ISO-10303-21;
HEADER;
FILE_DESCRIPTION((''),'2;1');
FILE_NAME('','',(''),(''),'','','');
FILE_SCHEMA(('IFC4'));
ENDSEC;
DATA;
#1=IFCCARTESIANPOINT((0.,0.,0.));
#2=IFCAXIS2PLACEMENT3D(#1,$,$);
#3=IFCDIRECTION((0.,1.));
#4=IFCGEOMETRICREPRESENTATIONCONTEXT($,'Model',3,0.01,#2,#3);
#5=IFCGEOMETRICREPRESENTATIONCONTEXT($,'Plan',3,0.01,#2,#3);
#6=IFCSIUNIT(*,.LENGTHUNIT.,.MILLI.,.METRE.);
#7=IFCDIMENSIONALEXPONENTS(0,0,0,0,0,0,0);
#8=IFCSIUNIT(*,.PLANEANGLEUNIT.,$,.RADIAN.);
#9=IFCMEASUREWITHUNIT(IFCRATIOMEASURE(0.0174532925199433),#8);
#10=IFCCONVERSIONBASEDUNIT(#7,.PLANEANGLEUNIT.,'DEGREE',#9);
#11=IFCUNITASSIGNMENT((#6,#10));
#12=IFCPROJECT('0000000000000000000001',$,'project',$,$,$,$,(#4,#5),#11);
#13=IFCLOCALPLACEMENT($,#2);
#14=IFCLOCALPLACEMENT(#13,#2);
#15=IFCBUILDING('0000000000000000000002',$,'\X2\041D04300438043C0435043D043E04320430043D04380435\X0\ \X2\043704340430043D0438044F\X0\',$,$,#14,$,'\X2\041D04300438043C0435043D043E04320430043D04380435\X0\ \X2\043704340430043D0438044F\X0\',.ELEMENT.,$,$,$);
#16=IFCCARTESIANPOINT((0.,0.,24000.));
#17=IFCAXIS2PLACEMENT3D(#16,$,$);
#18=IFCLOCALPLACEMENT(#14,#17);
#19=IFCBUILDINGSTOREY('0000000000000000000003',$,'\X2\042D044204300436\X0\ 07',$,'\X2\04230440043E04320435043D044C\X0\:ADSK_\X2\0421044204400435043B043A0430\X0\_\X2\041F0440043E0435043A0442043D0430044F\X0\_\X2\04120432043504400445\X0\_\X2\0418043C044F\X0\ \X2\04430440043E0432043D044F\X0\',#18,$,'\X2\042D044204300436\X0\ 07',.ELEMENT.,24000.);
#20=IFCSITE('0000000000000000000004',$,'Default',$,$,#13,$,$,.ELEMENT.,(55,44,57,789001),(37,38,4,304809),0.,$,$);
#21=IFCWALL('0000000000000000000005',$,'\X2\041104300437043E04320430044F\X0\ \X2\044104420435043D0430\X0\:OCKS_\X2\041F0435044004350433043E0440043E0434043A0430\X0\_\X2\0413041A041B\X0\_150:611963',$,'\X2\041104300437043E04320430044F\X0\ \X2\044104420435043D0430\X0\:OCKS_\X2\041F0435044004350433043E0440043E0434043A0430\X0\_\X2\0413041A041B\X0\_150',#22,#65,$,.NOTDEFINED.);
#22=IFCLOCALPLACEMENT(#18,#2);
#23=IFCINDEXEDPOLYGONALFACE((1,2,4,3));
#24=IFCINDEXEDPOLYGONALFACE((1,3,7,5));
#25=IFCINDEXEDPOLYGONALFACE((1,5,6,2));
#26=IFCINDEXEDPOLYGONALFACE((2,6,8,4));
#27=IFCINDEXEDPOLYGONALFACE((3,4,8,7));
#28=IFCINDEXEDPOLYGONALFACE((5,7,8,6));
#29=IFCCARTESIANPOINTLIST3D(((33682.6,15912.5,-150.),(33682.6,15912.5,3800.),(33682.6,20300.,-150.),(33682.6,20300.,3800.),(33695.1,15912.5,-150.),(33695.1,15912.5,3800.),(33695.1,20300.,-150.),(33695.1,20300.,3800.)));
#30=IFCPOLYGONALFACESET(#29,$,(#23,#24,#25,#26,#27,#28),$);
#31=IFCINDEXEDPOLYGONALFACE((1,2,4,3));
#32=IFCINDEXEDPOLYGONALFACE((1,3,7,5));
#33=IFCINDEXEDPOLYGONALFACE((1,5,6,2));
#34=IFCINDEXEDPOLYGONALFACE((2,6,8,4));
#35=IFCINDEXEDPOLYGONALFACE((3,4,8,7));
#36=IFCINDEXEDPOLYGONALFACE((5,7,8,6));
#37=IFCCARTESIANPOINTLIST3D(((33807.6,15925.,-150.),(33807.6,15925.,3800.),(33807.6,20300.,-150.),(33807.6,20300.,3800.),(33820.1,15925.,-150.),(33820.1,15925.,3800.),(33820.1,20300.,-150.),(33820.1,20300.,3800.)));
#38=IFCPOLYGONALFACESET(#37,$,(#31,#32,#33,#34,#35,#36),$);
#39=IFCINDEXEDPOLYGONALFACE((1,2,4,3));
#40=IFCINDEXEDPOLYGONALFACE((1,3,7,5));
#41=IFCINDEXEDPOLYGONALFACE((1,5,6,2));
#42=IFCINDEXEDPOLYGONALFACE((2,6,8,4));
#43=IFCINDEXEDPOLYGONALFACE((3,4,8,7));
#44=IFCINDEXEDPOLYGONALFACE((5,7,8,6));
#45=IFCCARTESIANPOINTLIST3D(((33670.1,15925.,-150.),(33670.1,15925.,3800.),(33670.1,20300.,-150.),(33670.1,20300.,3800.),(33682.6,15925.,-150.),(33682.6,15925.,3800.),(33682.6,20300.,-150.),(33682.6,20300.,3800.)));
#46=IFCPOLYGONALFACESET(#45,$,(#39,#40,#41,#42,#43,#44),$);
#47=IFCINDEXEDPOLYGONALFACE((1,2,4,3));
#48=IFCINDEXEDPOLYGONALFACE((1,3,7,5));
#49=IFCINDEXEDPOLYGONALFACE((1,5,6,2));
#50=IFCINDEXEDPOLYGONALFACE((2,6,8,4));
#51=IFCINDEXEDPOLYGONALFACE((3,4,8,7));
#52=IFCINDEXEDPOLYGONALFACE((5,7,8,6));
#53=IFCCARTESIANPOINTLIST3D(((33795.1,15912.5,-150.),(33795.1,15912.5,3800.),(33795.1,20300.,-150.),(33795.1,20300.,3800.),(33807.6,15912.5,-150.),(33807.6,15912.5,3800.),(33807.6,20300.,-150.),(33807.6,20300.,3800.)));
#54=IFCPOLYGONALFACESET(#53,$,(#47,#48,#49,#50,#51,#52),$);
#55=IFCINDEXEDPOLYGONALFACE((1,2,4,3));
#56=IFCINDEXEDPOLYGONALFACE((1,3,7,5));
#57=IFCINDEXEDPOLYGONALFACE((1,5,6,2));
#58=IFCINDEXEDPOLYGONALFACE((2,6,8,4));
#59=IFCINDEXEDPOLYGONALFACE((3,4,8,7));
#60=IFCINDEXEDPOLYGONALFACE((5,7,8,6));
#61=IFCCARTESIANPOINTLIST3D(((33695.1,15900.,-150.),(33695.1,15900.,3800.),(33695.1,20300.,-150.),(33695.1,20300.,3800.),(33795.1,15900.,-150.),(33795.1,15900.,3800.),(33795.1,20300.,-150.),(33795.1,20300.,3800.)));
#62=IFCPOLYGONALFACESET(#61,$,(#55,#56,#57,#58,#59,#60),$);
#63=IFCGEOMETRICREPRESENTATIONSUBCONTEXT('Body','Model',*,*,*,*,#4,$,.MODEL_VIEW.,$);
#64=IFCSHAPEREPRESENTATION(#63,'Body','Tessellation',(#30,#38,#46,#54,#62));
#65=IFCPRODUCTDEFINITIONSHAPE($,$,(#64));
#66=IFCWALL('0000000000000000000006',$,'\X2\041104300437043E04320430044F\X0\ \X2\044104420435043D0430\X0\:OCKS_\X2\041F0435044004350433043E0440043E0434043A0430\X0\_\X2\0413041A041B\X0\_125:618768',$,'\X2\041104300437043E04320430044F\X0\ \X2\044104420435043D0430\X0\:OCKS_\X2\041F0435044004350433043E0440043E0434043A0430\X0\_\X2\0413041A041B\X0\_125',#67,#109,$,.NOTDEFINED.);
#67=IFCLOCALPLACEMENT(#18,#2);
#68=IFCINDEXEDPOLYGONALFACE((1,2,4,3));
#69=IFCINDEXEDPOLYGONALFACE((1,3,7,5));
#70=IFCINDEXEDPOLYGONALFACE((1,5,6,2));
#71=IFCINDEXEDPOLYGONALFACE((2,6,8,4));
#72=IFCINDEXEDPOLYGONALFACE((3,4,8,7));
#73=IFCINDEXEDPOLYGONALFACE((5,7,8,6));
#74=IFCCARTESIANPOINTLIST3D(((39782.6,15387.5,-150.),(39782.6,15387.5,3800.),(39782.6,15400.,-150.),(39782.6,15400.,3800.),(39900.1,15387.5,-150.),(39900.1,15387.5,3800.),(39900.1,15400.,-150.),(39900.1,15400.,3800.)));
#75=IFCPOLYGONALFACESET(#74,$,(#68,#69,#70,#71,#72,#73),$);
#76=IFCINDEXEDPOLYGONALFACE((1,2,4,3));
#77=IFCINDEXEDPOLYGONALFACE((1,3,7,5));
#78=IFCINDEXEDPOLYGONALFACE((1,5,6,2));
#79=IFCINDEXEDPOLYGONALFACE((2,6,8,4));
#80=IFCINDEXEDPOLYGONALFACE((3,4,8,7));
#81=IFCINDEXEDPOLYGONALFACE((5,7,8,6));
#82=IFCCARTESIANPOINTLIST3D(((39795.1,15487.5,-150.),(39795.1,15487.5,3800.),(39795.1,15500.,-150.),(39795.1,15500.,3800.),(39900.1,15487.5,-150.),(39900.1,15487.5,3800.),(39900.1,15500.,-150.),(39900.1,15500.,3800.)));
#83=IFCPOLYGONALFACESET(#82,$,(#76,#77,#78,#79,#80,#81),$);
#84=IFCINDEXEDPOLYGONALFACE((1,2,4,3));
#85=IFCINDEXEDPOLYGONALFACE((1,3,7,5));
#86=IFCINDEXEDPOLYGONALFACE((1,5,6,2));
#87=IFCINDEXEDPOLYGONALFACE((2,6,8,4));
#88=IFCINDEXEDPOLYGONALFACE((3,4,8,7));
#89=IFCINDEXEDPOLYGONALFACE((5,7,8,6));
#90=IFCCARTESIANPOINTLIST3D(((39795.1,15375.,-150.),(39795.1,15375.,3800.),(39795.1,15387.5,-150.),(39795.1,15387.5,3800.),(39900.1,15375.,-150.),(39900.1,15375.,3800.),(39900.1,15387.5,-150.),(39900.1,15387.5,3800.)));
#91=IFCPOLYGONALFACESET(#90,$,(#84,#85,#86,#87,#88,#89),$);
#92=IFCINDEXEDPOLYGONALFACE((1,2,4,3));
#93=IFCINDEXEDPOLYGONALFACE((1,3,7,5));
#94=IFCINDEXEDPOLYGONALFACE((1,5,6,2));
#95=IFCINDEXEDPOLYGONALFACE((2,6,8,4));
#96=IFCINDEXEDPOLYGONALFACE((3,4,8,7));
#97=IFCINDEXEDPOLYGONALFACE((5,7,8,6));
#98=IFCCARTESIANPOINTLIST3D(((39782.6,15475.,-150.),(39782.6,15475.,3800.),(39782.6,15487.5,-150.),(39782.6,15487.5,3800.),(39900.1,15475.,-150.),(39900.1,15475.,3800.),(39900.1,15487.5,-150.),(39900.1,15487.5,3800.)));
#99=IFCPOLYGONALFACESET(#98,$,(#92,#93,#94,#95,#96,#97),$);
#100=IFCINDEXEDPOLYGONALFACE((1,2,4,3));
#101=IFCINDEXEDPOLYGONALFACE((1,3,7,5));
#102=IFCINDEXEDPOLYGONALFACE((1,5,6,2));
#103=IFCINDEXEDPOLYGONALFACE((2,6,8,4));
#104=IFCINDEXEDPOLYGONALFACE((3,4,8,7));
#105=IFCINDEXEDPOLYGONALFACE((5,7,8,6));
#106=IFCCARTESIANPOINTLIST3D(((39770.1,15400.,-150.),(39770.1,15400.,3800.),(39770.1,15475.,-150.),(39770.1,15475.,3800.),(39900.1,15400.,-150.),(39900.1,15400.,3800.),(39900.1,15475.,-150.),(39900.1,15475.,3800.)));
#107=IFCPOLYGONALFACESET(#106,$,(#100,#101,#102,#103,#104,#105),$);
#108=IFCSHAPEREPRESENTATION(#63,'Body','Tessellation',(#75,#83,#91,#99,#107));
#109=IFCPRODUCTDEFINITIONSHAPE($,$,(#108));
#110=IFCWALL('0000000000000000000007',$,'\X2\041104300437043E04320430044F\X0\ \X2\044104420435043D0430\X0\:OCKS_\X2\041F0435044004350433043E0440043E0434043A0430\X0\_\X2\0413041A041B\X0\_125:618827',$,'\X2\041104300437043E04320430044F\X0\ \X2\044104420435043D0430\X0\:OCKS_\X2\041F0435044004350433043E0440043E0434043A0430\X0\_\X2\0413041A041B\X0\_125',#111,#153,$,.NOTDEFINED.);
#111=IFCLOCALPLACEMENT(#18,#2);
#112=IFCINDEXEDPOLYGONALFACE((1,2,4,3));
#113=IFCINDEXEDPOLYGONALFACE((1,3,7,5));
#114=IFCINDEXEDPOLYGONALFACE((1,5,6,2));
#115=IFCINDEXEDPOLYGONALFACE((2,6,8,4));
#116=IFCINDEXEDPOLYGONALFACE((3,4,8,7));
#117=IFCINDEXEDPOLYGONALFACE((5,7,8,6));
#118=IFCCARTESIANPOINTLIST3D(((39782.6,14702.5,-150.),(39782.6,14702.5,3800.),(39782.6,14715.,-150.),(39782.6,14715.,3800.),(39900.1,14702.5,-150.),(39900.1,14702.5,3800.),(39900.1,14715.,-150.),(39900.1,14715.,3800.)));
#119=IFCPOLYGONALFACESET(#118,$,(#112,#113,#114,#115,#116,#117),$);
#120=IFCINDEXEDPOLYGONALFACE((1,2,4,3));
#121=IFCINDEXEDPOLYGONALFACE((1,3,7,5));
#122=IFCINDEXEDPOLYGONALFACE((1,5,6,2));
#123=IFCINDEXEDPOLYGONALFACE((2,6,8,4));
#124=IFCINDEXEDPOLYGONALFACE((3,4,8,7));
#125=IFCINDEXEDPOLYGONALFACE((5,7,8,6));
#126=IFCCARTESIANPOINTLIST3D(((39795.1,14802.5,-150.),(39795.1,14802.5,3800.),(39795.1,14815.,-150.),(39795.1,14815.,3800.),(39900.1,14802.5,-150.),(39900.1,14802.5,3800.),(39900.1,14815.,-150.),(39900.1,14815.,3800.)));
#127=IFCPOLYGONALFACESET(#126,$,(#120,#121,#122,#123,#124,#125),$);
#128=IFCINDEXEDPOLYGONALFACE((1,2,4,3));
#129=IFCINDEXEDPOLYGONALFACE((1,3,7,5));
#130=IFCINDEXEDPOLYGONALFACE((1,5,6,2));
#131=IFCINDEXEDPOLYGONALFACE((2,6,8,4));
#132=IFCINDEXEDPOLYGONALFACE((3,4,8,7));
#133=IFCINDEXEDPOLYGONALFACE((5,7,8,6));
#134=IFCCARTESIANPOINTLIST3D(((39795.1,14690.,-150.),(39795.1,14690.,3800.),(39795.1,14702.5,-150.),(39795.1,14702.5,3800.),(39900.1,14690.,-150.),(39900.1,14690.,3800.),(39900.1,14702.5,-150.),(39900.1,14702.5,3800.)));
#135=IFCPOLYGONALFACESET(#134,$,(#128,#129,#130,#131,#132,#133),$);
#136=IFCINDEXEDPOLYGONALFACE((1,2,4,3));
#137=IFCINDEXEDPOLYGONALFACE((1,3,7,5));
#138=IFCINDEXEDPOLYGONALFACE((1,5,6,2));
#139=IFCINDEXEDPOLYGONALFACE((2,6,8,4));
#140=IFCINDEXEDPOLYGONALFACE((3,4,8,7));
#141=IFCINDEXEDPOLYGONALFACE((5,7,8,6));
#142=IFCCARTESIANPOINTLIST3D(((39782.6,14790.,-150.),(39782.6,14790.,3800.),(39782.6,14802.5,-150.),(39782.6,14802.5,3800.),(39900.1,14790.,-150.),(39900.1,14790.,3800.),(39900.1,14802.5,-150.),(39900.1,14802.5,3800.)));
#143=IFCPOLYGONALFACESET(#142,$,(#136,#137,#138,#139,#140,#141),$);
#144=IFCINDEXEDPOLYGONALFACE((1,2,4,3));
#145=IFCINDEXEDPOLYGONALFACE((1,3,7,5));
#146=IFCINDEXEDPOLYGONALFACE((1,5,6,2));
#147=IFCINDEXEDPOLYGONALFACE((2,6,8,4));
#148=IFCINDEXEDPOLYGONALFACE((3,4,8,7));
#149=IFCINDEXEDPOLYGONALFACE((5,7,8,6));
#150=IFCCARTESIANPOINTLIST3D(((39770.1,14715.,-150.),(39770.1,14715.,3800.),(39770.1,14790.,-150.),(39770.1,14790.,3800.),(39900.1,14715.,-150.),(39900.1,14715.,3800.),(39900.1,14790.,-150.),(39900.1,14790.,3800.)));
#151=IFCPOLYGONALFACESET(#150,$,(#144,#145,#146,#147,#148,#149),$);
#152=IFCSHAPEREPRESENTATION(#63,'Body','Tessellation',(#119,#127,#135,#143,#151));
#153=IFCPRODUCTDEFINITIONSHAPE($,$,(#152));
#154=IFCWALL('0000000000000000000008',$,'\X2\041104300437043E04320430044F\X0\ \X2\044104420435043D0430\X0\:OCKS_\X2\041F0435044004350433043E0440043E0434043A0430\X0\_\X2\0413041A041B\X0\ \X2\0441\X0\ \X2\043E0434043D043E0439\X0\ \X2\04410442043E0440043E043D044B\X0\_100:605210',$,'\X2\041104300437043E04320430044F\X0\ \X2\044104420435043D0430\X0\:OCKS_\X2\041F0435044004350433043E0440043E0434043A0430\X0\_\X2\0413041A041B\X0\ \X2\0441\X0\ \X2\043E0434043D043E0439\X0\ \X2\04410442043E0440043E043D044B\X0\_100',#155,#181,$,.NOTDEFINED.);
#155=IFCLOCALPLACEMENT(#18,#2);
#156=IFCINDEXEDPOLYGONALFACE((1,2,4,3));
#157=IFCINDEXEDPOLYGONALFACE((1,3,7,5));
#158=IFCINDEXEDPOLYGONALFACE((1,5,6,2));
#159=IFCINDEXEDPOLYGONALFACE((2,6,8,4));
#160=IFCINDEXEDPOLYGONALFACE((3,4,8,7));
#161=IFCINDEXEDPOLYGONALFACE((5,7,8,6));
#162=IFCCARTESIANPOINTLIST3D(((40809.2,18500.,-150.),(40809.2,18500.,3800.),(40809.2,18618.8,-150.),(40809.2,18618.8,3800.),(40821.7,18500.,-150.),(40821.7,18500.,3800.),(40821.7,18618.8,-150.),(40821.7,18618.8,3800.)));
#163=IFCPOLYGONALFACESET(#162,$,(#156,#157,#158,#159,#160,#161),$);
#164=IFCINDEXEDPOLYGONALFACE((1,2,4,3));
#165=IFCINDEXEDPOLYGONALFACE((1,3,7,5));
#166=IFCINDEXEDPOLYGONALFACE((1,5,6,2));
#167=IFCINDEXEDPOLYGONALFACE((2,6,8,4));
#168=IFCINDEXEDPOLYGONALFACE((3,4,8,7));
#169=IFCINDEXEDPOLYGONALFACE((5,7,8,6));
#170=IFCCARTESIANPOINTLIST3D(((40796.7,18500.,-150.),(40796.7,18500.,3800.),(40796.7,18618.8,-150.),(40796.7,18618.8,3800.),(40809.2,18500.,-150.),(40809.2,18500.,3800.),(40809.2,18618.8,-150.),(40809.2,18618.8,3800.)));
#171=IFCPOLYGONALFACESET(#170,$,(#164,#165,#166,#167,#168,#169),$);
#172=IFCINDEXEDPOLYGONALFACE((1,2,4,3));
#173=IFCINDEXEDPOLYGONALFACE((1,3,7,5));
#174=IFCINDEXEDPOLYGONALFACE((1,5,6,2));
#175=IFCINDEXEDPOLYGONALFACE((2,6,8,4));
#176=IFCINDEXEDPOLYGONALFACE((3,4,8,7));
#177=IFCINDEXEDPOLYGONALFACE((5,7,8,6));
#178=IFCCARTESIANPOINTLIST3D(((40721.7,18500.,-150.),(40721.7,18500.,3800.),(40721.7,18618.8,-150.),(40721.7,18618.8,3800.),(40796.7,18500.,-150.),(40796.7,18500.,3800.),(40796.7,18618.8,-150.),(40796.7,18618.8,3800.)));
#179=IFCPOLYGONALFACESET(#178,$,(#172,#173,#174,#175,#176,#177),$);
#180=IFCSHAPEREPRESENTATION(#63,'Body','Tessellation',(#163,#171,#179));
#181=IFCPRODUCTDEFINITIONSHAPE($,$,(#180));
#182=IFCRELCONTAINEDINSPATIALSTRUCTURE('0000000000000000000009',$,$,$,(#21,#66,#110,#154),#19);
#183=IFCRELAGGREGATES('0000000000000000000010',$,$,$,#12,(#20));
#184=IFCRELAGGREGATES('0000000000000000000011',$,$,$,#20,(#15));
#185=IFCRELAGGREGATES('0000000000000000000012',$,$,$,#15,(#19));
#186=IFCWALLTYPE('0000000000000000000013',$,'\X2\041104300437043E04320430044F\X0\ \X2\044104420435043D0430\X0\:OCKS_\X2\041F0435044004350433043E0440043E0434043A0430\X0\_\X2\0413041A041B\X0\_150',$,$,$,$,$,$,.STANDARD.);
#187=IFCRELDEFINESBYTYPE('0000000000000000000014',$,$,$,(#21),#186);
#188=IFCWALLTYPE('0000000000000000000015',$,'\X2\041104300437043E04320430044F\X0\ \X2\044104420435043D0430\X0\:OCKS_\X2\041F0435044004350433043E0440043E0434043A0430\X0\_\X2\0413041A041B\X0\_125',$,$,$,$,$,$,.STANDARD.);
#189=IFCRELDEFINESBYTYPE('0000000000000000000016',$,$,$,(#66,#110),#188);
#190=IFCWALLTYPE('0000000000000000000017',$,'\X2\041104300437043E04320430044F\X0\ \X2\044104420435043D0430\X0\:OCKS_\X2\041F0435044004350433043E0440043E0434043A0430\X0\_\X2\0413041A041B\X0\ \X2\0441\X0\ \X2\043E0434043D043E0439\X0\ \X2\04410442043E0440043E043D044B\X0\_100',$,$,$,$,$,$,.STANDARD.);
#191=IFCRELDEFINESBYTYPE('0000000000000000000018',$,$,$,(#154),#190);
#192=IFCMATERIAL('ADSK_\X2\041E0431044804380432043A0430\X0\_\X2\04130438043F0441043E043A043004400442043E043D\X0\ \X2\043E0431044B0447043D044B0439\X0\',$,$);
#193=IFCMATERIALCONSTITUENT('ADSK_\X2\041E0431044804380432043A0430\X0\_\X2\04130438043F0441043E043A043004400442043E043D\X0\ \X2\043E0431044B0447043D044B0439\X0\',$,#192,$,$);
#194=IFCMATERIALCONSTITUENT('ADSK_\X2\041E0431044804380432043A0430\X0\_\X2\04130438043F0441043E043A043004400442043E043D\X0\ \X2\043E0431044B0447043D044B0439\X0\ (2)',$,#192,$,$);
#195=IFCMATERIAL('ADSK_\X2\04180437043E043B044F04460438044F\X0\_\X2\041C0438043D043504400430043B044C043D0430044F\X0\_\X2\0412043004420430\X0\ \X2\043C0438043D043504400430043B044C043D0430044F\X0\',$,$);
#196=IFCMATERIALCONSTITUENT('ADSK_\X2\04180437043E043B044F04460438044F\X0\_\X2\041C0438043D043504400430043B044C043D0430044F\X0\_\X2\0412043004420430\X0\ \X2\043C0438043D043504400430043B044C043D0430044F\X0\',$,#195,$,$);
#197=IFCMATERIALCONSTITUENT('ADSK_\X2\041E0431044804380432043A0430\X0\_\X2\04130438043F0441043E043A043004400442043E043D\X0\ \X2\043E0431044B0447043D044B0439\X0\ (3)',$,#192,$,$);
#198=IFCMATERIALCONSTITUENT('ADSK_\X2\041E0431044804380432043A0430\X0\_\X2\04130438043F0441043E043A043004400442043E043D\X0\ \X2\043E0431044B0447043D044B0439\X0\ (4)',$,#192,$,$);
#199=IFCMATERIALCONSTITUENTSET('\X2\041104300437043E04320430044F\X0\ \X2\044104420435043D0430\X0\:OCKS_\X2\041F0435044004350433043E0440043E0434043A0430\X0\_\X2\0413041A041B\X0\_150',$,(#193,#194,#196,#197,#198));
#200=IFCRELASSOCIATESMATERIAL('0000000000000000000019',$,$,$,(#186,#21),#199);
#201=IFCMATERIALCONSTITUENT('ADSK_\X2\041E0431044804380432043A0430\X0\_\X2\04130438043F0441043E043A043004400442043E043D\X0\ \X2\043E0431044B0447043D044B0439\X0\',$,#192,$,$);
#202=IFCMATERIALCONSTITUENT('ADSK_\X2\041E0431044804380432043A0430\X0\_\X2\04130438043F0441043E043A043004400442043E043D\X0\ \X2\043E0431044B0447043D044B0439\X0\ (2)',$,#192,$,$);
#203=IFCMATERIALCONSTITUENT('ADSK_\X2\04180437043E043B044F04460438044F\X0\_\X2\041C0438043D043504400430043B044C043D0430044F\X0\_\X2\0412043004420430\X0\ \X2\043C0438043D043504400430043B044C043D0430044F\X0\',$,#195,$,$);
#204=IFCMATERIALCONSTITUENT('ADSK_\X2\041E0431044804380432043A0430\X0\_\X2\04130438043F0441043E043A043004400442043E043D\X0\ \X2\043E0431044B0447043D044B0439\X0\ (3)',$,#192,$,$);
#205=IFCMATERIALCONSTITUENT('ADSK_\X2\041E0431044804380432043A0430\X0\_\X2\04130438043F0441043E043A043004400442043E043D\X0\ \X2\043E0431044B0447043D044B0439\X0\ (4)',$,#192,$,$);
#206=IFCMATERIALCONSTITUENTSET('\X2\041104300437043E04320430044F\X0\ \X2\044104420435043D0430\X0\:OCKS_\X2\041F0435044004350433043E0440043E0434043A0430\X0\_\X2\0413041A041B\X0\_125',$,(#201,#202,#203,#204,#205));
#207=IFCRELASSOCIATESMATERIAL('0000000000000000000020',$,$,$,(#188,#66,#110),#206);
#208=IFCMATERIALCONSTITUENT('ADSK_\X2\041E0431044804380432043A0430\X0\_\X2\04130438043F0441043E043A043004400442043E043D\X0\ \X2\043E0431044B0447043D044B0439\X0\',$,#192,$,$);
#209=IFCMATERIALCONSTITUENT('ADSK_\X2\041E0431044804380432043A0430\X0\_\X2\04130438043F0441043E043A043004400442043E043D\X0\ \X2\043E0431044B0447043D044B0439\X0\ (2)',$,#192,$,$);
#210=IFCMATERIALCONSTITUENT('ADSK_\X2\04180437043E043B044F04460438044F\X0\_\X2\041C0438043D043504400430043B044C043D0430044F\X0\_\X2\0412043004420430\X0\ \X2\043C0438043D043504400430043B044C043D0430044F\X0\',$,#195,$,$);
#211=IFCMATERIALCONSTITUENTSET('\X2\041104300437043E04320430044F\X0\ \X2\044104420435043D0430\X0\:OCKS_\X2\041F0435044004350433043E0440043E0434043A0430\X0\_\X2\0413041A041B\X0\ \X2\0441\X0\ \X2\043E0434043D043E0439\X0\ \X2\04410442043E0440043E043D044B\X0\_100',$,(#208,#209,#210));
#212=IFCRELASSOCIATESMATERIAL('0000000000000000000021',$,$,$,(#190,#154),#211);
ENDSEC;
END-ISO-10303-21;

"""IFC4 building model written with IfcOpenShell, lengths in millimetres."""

from ifc_helpers import new_model, entity, si_unit, converted_unit, direction, frame, origin, place, context, subcontext, project, spatial, indexed_curve, outline, extrude, material, constituent, constituent_set, type_object, element, save


model = new_model("IFC4")

# Units and contexts
model_context = context("Model", 3, precision=0.01, world=origin(), true_north=direction((0.0, 1.0)))
plan_context = context("Plan", 3, precision=0.01, world=origin(), true_north=direction((0.0, 1.0)))
body_context = subcontext(model_context, "Body", "Model", "MODEL_VIEW")
ifc_project = project(units=[si_unit("LENGTHUNIT", "METRE", prefix="MILLI"), converted_unit("PLANEANGLEUNIT", "DEGREE", entity("IfcRatioMeasure", 0.0174532925199433), si_unit("PLANEANGLEUNIT", "RADIAN"), dimensions=[0, 0, 0, 0, 0, 0, 0])], contexts=[model_context, plan_context])

# Site, building, storey
site_placement = place(None, frame((0.0, 0.0, 0.0)))
site = spatial("IfcSite", under=ifc_project, at=site_placement, Name="Default", CompositionType="ELEMENT", RefLatitude=(55, 44, 57, 789001), RefLongitude=(37, 38, 4, 304809), RefElevation=0.0)
building_placement = place(site_placement, origin())
building = spatial("IfcBuilding", under=site, at=building_placement, Name="Наименование здания", LongName="Наименование здания", CompositionType="ELEMENT")
storey_placement = place(building_placement, frame((0.0, 0.0, 24000.0)))
storey = spatial("IfcBuildingStorey", under=building, at=storey_placement, Name="Этаж 07", ObjectType="Уровень:ADSK_Стрелка_Проектная_Вверх_Имя уровня", LongName="Этаж 07", CompositionType="ELEMENT", Elevation=24000.0)

# Shared definitions
ifc_material_1 = material(Name="ADSK_Обшивка_Гипсокартон обычный")
ifc_constituent_1 = constituent(ifc_material_1, Name="ADSK_Обшивка_Гипсокартон обычный")
ifc_constituent_2 = constituent(ifc_material_1, Name="ADSK_Обшивка_Гипсокартон обычный (2)")
ifc_material_2 = material(Name="ADSK_Изоляция_Минеральная_Вата минеральная")
ifc_constituent_3 = constituent(ifc_material_2, Name="ADSK_Изоляция_Минеральная_Вата минеральная")
ifc_constituent_4 = constituent(ifc_material_1, Name="ADSK_Обшивка_Гипсокартон обычный (3)")
ifc_constituent_5 = constituent(ifc_material_1, Name="ADSK_Обшивка_Гипсокартон обычный (4)")
ifc_constituent_set_1 = constituent_set(constituents=[ifc_constituent_1, ifc_constituent_2, ifc_constituent_3, ifc_constituent_4, ifc_constituent_5], Name="Базовая стена:OCKS_Перегородка_ГКЛ_150")
wall_type_1 = type_object("IfcWallType", Name="Базовая стена:OCKS_Перегородка_ГКЛ_150", PredefinedType="STANDARD", material=ifc_constituent_set_1)

# Wall
wall_1_placement = place(storey_placement, frame((33745.1, 20300.0, -150.0), z_axis=(0.0, 0.0, 1.0), x_axis=(0.0, -1.0, 0.0)))
element("IfcWall", 1, at=wall_1_placement, inside=storey, type_object=wall_type_1, material=ifc_constituent_set_1, Name="Базовая стена:OCKS_Перегородка_ГКЛ_150:611963", ObjectType="Базовая стена:OCKS_Перегородка_ГКЛ_150", PredefinedType="NOTDEFINED", context=body_context, shape_type="SweptSolid", body=[
    extrude(outline(indexed_curve([(-2193.7, -6.2), (2193.7, -6.2), (2193.7, 6.2), (-2193.7, 6.2), (-2193.7, -6.2)], self_intersect=False)), frame((2193.7, -56.3, 0.0)), (0.0, 0.0, 1.0), 3950.0),
    extrude(outline(indexed_curve([(-6.3, -2187.5), (6.2, -2187.5), (6.3, 2187.5), (-6.2, 2187.5), (-6.3, -2187.5)], self_intersect=False)), frame((2187.5, 68.8, 0.0), z_axis=(0.0, 0.0, 1.0), x_axis=(0.0, -1.0, 0.0)), (0.0, 0.0, 1.0), 3950.0),
    extrude(outline(indexed_curve([(-6.3, -2187.5), (6.2, -2187.5), (6.3, 2187.5), (-6.2, 2187.5), (-6.3, -2187.5)], self_intersect=False)), frame((2187.5, -68.8, 0.0), z_axis=(0.0, 0.0, 1.0), x_axis=(0.0, 1.0, 0.0)), (0.0, 0.0, 1.0), 3950.0),
    extrude(outline(indexed_curve([(-2193.7, -6.2), (2193.7, -6.2), (2193.7, 6.2), (-2193.7, 6.2), (-2193.7, -6.2)], self_intersect=False)), frame((2193.7, 56.2, 0.0)), (0.0, 0.0, 1.0), 3950.0),
    extrude(outline(indexed_curve([(-2200.0, -50.0), (2200.0, -50.0), (2200.0, 50.0), (-2200.0, 50.0), (-2200.0, -50.0)], self_intersect=False)), frame((2200.0, 0.0, 0.0)), (0.0, 0.0, 1.0), 3950.0),
])

# Walls
ifc_constituent_6 = constituent(ifc_material_1, Name="ADSK_Обшивка_Гипсокартон обычный")
ifc_constituent_7 = constituent(ifc_material_1, Name="ADSK_Обшивка_Гипсокартон обычный (2)")
ifc_constituent_8 = constituent(ifc_material_2, Name="ADSK_Изоляция_Минеральная_Вата минеральная")
ifc_constituent_9 = constituent(ifc_material_1, Name="ADSK_Обшивка_Гипсокартон обычный (3)")
ifc_constituent_10 = constituent(ifc_material_1, Name="ADSK_Обшивка_Гипсокартон обычный (4)")
ifc_constituent_set_2 = constituent_set(constituents=[ifc_constituent_6, ifc_constituent_7, ifc_constituent_8, ifc_constituent_9, ifc_constituent_10], Name="Базовая стена:OCKS_Перегородка_ГКЛ_125")
wall_type_2 = type_object("IfcWallType", Name="Базовая стена:OCKS_Перегородка_ГКЛ_125", PredefinedType="STANDARD", material=ifc_constituent_set_2)
wall_2_placement = place(storey_placement, frame((39900.1, 15437.5, -150.0), z_axis=(0.0, 0.0, 1.0), x_axis=(-1.0, 0.0, 0.0)))
element("IfcWall", 2, at=wall_2_placement, inside=storey, type_object=wall_type_2, material=ifc_constituent_set_2, Name="Базовая стена:OCKS_Перегородка_ГКЛ_125:618768", ObjectType="Базовая стена:OCKS_Перегородка_ГКЛ_125", PredefinedType="NOTDEFINED", context=body_context, shape_type="SweptSolid", body=[
    extrude(outline(indexed_curve([(-58.8, -6.3), (58.8, -6.3), (58.8, 6.2), (-58.8, 6.2), (-58.8, -6.3)], self_intersect=False)), frame((58.8, 43.8, 0.0)), (0.0, 0.0, 1.0), 3950.0),
    extrude(outline(indexed_curve([(-6.3, -52.5), (6.2, -52.5), (6.2, 52.5), (-6.3, 52.5), (-6.3, -52.5)], self_intersect=False)), frame((52.5, -56.2, 0.0), z_axis=(0.0, 0.0, 1.0), x_axis=(0.0, 1.0, 0.0)), (0.0, 0.0, 1.0), 3950.0),
    extrude(outline(indexed_curve([(-6.3, -52.5), (6.3, -52.5), (6.3, 52.5), (-6.3, 52.5), (-6.3, -52.5)], self_intersect=False)), frame((52.5, 56.3, 0.0), z_axis=(0.0, 0.0, 1.0), x_axis=(0.0, -1.0, 0.0)), (0.0, 0.0, 1.0), 3950.0),
    extrude(outline(indexed_curve([(-58.8, -6.2), (58.8, -6.2), (58.8, 6.3), (-58.8, 6.3), (-58.8, -6.2)], self_intersect=False)), frame((58.8, -43.8, 0.0)), (0.0, 0.0, 1.0), 3950.0),
    extrude(outline(indexed_curve([(-65.0, -37.5), (65.0, -37.5), (65.0, 37.5), (-65.0, 37.5), (-65.0, -37.5)], self_intersect=False)), frame((65.0, 0.0, 0.0)), (0.0, 0.0, 1.0), 3950.0),
])
wall_3_placement = place(storey_placement, frame((39900.1, 14752.5, -150.0), z_axis=(0.0, 0.0, 1.0), x_axis=(-1.0, 0.0, 0.0)))
element("IfcWall", 3, at=wall_3_placement, inside=storey, type_object=wall_type_2, material=ifc_constituent_set_2, Name="Базовая стена:OCKS_Перегородка_ГКЛ_125:618827", ObjectType="Базовая стена:OCKS_Перегородка_ГКЛ_125", PredefinedType="NOTDEFINED", context=body_context, shape_type="SweptSolid", body=[
    extrude(outline(indexed_curve([(-58.8, -6.2), (58.8, -6.2), (58.8, 6.3), (-58.8, 6.3), (-58.8, -6.2)], self_intersect=False)), frame((58.8, 43.7, 0.0)), (0.0, 0.0, 1.0), 3950.0),
    extrude(outline(indexed_curve([(-6.2, -52.5), (6.3, -52.5), (6.3, 52.5), (-6.2, 52.5), (-6.2, -52.5)], self_intersect=False)), frame((52.5, -56.3, 0.0), z_axis=(0.0, 0.0, 1.0), x_axis=(0.0, 1.0, 0.0)), (0.0, 0.0, 1.0), 3950.0),
    extrude(outline(indexed_curve([(-6.3, -52.5), (6.3, -52.5), (6.3, 52.5), (-6.3, 52.5), (-6.3, -52.5)], self_intersect=False)), frame((52.5, 56.3, 0.0), z_axis=(0.0, 0.0, 1.0), x_axis=(0.0, -1.0, 0.0)), (0.0, 0.0, 1.0), 3950.0),
    extrude(outline(indexed_curve([(-58.8, -6.2), (58.8, -6.2), (58.8, 6.3), (-58.8, 6.3), (-58.8, -6.2)], self_intersect=False)), frame((58.8, -43.8, 0.0)), (0.0, 0.0, 1.0), 3950.0),
    extrude(outline(indexed_curve([(-65.0, -37.5), (65.0, -37.5), (65.0, 37.5), (-65.0, 37.5), (-65.0, -37.5)], self_intersect=False)), frame((65.0, 0.0, 0.0)), (0.0, 0.0, 1.0), 3950.0),
])
ifc_constituent_11 = constituent(ifc_material_1, Name="ADSK_Обшивка_Гипсокартон обычный")
ifc_constituent_12 = constituent(ifc_material_1, Name="ADSK_Обшивка_Гипсокартон обычный (2)")
ifc_constituent_13 = constituent(ifc_material_2, Name="ADSK_Изоляция_Минеральная_Вата минеральная")
ifc_constituent_set_3 = constituent_set(constituents=[ifc_constituent_11, ifc_constituent_12, ifc_constituent_13], Name="Базовая стена:OCKS_Перегородка_ГКЛ с одной стороны_100")
wall_type_3 = type_object("IfcWallType", Name="Базовая стена:OCKS_Перегородка_ГКЛ с одной стороны_100", PredefinedType="STANDARD", material=ifc_constituent_set_3)
wall_4_placement = place(storey_placement, frame((40771.7, 18500.0, -150.0), z_axis=(0.0, 0.0, 1.0), x_axis=(0.0, 1.0, 0.0)))
element("IfcWall", 4, at=wall_4_placement, inside=storey, type_object=wall_type_3, material=ifc_constituent_set_3, Name="Базовая стена:OCKS_Перегородка_ГКЛ с одной стороны_100:605210", ObjectType="Базовая стена:OCKS_Перегородка_ГКЛ с одной стороны_100", PredefinedType="NOTDEFINED", context=body_context, shape_type="SweptSolid", body=[
    extrude(outline(indexed_curve([(-6.3, -59.4), (6.3, -59.4), (6.3, 59.4), (-6.3, 59.4), (-6.3, -59.4)], self_intersect=False)), frame((59.4, -43.8, 0.0), z_axis=(0.0, 0.0, 1.0), x_axis=(0.0, 1.0, 0.0)), (0.0, 0.0, 1.0), 3950.0),
    extrude(outline(indexed_curve([(-59.4, -6.3), (59.4, -6.3), (59.4, 6.2), (-59.4, 6.2), (-59.4, -6.3)], self_intersect=False)), frame((59.4, -31.2, 0.0)), (0.0, 0.0, 1.0), 3950.0),
    extrude(outline(indexed_curve([(-37.5, -59.4), (37.5, -59.4), (37.5, 59.4), (-37.5, 59.4), (-37.5, -59.4)], self_intersect=False)), frame((59.4, 12.5, 0.0), z_axis=(0.0, 0.0, 1.0), x_axis=(0.0, -1.0, 0.0)), (0.0, 0.0, 1.0), 3950.0),
])

save(model, "model.ifc")
